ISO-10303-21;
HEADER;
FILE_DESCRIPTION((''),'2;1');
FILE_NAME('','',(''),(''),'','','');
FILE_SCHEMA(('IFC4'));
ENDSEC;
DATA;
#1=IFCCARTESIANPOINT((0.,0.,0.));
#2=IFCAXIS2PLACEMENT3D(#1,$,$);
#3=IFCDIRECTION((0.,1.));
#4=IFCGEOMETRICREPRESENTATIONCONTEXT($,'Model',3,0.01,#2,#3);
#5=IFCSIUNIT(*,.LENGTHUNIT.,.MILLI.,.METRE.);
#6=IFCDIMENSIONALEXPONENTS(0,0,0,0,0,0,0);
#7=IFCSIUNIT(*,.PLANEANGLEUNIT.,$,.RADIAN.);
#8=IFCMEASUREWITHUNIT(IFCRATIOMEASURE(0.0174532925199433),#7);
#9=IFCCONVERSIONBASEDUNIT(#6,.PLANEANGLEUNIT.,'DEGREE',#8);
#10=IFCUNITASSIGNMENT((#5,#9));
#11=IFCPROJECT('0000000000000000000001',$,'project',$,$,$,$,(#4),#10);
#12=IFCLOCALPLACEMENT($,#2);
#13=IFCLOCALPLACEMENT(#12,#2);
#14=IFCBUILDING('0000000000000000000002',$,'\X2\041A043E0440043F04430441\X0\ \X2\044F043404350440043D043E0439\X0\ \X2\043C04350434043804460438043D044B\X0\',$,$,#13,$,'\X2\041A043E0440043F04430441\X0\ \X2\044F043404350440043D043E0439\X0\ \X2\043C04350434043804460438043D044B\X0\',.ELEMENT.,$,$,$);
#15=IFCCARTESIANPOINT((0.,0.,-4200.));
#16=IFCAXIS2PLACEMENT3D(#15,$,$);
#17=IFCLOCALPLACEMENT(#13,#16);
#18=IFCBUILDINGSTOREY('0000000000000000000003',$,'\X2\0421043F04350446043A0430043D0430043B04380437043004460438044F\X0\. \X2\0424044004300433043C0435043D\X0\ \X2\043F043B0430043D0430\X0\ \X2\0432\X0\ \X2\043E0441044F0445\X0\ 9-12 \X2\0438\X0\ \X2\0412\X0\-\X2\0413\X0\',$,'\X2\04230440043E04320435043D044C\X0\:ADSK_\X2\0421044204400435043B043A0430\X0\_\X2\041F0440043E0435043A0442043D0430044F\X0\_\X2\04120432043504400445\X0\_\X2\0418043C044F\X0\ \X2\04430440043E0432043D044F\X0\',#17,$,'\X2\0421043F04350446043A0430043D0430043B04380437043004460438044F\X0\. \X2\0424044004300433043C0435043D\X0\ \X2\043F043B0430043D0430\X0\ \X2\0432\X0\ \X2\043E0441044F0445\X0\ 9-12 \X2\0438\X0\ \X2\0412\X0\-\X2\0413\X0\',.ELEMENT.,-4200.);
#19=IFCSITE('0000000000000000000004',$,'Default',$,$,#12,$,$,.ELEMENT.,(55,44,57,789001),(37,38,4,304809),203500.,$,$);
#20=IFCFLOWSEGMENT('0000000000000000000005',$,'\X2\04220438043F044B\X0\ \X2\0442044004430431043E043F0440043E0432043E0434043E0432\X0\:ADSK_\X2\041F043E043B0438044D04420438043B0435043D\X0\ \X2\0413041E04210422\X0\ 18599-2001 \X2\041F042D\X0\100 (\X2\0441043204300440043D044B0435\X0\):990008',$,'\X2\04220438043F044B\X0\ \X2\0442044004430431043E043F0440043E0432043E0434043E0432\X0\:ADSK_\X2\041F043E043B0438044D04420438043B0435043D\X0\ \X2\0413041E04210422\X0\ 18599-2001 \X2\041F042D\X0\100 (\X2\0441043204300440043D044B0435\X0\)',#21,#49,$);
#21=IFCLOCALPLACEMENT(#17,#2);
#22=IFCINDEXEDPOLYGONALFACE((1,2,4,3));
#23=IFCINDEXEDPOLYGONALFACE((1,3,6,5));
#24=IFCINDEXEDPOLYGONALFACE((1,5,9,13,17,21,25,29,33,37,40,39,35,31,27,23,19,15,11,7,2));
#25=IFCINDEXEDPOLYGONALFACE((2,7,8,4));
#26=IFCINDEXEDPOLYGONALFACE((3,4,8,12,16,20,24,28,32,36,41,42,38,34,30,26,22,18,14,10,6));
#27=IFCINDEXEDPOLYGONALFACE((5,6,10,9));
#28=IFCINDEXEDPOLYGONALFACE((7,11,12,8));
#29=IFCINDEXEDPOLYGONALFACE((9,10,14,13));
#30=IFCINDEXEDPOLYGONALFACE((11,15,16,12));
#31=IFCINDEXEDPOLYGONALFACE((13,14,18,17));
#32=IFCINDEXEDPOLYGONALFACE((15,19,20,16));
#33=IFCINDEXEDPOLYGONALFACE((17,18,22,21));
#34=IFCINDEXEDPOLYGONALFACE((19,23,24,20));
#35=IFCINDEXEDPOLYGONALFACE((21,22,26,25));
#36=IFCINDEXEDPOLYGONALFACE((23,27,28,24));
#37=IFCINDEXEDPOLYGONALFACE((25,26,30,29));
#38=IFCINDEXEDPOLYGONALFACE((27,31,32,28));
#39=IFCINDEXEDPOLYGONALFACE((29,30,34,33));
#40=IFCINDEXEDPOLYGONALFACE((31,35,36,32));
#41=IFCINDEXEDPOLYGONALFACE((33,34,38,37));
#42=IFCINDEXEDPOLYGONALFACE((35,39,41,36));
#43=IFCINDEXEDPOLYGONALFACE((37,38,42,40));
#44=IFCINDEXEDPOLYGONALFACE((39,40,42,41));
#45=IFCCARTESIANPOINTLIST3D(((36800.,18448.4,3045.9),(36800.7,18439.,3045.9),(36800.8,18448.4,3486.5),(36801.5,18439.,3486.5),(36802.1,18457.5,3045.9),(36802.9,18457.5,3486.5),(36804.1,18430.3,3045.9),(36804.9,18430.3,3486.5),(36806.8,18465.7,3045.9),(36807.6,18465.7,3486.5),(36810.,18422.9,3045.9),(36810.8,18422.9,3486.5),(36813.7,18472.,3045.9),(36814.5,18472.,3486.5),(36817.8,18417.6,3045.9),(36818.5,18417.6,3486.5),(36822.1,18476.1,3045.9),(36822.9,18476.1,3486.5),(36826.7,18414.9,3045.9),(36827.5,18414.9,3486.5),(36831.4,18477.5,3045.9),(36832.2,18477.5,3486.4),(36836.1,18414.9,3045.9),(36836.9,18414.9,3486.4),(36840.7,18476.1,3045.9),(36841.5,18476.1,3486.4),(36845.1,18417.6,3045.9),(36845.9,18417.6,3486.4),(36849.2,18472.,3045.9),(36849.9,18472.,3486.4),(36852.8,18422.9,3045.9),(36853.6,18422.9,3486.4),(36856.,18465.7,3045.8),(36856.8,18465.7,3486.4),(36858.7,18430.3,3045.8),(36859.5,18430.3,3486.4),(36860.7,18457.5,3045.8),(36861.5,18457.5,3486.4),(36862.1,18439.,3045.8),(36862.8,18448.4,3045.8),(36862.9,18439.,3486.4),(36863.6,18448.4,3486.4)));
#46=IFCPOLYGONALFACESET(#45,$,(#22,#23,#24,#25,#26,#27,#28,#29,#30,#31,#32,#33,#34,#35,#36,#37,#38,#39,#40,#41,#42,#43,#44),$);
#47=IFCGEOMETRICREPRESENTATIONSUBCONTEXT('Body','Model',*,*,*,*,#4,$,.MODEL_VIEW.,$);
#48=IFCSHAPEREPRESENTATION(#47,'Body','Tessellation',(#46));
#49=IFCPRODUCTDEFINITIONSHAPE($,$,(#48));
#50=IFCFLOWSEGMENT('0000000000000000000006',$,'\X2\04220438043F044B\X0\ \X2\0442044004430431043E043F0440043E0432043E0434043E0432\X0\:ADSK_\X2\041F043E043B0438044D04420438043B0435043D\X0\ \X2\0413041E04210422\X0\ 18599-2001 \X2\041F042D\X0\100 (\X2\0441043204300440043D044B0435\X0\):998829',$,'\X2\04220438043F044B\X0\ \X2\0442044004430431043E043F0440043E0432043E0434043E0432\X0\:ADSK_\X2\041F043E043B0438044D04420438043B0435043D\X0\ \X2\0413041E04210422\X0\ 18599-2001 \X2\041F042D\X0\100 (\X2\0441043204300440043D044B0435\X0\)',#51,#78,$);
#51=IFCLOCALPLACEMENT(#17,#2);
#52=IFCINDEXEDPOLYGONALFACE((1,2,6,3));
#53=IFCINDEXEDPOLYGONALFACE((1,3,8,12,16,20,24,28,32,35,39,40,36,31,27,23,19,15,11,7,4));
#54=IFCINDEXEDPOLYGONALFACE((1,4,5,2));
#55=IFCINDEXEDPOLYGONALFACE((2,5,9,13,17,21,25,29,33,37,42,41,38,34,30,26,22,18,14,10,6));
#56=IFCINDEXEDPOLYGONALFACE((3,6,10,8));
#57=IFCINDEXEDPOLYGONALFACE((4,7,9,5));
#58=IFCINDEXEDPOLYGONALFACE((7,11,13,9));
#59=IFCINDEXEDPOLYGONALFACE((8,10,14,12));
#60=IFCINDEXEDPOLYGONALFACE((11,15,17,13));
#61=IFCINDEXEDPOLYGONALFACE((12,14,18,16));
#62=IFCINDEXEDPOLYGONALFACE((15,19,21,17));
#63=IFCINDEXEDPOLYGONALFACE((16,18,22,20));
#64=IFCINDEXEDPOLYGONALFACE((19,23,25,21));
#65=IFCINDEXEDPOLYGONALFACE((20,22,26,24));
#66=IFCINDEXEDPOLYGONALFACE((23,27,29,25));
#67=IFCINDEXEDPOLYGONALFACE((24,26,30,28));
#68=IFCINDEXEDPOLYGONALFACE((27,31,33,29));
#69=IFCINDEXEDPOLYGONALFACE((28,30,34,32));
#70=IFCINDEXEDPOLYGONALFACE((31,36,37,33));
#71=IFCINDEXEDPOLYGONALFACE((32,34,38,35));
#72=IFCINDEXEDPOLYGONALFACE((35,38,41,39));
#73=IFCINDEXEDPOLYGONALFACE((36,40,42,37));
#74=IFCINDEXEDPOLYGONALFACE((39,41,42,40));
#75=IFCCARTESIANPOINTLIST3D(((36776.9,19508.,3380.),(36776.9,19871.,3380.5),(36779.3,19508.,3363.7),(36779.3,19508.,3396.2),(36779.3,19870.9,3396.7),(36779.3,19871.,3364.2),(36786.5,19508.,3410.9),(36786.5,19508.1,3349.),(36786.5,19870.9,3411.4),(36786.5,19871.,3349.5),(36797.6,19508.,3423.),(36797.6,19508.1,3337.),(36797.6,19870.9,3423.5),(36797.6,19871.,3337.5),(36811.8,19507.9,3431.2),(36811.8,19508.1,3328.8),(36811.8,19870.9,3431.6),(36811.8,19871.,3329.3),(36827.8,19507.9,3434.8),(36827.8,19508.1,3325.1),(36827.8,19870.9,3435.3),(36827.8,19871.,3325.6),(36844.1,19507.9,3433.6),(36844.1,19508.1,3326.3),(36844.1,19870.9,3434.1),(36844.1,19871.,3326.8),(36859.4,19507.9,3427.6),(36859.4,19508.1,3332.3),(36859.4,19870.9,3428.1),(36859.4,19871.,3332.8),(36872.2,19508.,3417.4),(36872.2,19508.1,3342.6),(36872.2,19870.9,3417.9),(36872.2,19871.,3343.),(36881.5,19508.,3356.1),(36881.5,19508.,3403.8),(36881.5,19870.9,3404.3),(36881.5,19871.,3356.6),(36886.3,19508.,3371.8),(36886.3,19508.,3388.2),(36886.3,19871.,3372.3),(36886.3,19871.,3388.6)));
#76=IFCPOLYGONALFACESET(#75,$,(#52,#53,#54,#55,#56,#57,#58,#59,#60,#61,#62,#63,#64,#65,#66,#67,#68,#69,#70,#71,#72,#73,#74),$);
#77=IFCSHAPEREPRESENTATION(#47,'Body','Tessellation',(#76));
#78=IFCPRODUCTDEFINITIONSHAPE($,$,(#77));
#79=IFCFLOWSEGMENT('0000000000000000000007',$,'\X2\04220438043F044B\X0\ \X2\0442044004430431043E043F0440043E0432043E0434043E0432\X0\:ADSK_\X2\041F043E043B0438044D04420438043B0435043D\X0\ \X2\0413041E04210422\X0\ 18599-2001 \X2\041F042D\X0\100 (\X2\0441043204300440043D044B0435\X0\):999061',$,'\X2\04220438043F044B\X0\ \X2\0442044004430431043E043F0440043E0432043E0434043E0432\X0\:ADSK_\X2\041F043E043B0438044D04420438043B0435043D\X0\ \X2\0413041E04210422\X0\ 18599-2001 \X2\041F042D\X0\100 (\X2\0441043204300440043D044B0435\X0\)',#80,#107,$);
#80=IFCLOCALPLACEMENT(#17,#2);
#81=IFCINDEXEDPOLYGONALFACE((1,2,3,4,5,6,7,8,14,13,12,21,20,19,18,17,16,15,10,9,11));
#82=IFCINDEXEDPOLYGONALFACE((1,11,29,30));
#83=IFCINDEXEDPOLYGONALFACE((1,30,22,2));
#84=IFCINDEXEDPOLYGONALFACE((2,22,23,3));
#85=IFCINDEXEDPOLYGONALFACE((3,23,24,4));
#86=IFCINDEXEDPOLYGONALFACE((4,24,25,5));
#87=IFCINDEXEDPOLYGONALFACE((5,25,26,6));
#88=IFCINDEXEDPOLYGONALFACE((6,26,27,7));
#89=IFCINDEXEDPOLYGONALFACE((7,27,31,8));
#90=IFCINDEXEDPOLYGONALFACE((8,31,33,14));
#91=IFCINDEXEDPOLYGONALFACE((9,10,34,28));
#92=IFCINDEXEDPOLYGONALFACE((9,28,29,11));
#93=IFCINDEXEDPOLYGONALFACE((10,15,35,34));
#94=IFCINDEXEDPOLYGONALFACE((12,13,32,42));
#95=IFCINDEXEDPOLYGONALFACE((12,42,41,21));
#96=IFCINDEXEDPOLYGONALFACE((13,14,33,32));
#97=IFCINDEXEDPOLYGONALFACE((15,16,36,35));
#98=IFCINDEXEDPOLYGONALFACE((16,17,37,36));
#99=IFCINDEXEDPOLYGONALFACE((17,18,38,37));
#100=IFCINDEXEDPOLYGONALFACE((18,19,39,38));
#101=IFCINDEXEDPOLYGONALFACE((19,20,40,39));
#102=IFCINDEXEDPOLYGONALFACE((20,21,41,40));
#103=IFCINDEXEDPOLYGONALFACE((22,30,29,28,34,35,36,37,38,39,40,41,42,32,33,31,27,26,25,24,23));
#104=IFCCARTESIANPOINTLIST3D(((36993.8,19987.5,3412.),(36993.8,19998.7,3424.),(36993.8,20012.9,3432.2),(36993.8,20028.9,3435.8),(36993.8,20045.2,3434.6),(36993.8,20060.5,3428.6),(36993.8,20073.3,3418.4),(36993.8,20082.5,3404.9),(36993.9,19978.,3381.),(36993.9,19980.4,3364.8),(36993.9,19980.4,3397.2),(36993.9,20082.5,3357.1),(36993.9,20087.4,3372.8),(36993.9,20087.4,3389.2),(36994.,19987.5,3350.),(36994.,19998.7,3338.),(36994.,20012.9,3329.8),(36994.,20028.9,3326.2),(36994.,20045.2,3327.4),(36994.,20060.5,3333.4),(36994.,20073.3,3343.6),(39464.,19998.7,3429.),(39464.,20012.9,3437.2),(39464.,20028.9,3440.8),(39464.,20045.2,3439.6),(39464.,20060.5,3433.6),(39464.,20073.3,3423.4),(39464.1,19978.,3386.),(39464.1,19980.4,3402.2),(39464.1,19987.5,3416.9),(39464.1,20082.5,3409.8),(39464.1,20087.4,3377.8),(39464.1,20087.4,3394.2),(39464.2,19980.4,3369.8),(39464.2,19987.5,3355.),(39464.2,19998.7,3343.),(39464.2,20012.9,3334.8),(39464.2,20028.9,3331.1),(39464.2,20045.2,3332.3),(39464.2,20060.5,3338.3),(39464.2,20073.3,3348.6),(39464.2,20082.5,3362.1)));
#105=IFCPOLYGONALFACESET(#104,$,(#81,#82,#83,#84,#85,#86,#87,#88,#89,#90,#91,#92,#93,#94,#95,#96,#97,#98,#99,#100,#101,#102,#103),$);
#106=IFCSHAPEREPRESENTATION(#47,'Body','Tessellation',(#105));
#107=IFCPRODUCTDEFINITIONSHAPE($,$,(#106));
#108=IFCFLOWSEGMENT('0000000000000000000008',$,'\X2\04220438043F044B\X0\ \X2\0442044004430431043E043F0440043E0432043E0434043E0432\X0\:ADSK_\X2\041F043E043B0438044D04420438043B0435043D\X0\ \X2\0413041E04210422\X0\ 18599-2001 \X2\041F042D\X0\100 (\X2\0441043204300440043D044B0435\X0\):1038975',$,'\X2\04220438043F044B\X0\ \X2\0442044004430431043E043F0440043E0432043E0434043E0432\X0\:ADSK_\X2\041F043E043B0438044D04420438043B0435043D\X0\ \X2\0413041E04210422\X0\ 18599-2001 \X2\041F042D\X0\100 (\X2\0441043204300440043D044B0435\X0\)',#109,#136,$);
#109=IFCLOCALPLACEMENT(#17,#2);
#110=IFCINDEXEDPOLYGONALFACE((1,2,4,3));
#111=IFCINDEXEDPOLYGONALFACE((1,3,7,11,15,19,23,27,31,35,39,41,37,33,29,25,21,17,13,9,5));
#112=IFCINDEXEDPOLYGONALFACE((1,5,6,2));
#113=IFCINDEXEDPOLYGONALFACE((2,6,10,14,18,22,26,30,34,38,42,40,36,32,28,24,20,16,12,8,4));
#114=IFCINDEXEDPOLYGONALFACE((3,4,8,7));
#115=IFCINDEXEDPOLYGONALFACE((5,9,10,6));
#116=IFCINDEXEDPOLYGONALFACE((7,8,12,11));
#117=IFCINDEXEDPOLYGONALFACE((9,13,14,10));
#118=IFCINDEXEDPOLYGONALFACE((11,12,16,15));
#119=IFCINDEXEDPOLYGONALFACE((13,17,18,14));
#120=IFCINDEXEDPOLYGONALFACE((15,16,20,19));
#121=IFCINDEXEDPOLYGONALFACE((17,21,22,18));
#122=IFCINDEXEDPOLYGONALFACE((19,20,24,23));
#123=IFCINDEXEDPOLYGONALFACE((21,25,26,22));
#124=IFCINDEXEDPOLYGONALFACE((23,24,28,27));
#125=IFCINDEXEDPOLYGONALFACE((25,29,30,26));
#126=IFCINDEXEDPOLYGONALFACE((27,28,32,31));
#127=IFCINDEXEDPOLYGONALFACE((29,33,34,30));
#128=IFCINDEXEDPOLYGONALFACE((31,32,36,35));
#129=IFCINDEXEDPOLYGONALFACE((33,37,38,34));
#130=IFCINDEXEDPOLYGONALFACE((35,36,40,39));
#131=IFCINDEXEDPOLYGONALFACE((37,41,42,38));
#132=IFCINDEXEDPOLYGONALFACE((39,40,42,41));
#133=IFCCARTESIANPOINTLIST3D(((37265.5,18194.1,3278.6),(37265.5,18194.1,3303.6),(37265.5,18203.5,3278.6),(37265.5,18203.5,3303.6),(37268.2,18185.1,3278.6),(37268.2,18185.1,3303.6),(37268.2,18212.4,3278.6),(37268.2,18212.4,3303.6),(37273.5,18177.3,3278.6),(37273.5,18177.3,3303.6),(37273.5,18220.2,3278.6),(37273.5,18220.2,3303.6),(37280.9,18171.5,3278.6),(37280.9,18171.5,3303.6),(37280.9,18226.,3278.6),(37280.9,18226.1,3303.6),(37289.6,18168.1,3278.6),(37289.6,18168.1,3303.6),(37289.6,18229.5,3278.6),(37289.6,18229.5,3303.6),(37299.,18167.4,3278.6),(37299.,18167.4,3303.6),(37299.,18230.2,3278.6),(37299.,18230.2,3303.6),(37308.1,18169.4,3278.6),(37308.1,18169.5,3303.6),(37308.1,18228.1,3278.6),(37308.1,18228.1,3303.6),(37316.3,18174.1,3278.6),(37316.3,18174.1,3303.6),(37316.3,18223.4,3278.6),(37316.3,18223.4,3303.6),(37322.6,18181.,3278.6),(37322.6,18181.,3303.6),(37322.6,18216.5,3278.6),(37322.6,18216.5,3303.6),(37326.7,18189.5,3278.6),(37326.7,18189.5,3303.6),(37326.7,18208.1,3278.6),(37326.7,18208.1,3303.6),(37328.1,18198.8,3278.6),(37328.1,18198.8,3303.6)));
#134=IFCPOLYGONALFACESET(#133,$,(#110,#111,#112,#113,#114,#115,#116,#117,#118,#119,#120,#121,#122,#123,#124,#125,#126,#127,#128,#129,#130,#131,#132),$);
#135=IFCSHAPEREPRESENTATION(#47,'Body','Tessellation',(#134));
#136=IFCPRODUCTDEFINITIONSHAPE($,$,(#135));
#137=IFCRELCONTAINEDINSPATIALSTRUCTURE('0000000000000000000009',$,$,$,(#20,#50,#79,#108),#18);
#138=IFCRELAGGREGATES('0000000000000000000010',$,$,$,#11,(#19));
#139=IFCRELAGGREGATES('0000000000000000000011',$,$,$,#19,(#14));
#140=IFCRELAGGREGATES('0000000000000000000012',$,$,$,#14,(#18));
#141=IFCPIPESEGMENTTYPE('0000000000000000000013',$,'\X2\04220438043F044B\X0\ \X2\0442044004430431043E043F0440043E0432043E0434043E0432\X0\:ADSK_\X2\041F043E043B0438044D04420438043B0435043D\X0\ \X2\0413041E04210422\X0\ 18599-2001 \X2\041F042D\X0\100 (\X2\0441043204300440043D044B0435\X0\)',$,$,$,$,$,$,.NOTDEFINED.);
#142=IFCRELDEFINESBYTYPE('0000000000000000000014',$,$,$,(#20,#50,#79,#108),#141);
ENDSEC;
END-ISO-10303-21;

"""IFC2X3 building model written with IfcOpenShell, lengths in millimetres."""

from ifc_helpers import new_model, entity, si_unit, converted_unit, direction, frame, origin, origin_2d_with_axis, place, context, subcontext, project, spatial, circle, extrude, type_object, element, save


model = new_model("IFC2X3")

# Units and contexts
model_context = context("Model", 3, precision=0.01, world=origin(), true_north=direction((0.0, 1.0)))
body_context = subcontext(model_context, "Body", "Model", "MODEL_VIEW")
ifc_project = project(units=[si_unit("LENGTHUNIT", "METRE", prefix="MILLI"), converted_unit("PLANEANGLEUNIT", "DEGREE", entity("IfcRatioMeasure", 0.0174532925199433), si_unit("PLANEANGLEUNIT", "RADIAN"), dimensions=[0, 0, 0, 0, 0, 0, 0])], contexts=[model_context])

# Site, building, storey
site_placement = place(None, origin())
site = spatial("IfcSite", under=ifc_project, at=site_placement, Name="Default", CompositionType="ELEMENT", RefLatitude=(55, 44, 57, 789001), RefLongitude=(37, 38, 4, 304809), RefElevation=203500.0)
building_placement = place(site_placement, origin())
building = spatial("IfcBuilding", under=site, at=building_placement, Name="Корпус ядерной медицины", LongName="Корпус ядерной медицины", CompositionType="ELEMENT")
storey_placement = place(building_placement, frame((0.0, 0.0, -4200.0)))
storey = spatial("IfcBuildingStorey", under=building, at=storey_placement, Name="Спецканализация. Фрагмен плана в осях 9-12 и В-Г", ObjectType="Уровень:ADSK_Стрелка_Проектная_Вверх_Имя уровня", LongName="Спецканализация. Фрагмен плана в осях 9-12 и В-Г", CompositionType="ELEMENT", Elevation=-4200.0)

# Flow segments
pipe_segment_type = type_object("IfcPipeSegmentType", Name="Типы трубопроводов:ADSK_Полиэтилен ГОСТ 18599-2001 ПЭ100 (сварные)", PredefinedType="NOTDEFINED")
flow_segment_1_placement = place(storey_placement, frame((36798.3, 18412.9, 3045.8)))
element("IfcFlowSegment", 1, at=flow_segment_1_placement, inside=storey, type_object=pipe_segment_type, Name="Типы трубопроводов:ADSK_Полиэтилен ГОСТ 18599-2001 ПЭ100 (сварные):990008", ObjectType="Типы трубопроводов:ADSK_Полиэтилен ГОСТ 18599-2001 ПЭ100 (сварные)", context=body_context, shape_type="SweptSolid", body=[
    extrude(circle(Radius=31.5, at=origin_2d_with_axis()), frame((33.1, 33.1, 0.1), z_axis=(0.001773, 0.0, 0.999998), x_axis=(0.0, 1.0, 0.0)), (0.0, 0.0, 1.0), 440.6),
])
flow_segment_2_placement = place(storey_placement, frame((36775.3, 19507.9, 3323.4)))
element("IfcFlowSegment", 2, at=flow_segment_2_placement, inside=storey, type_object=pipe_segment_type, Name="Типы трубопроводов:ADSK_Полиэтилен ГОСТ 18599-2001 ПЭ100 (сварные):998829", ObjectType="Типы трубопроводов:ADSK_Полиэтилен ГОСТ 18599-2001 ПЭ100 (сварные)", context=body_context, shape_type="SweptSolid", body=[
    extrude(circle(Radius=55.0, at=origin_2d_with_axis()), frame((56.6, 0.1, 56.6), z_axis=(0.0, 0.999999, 0.001352), x_axis=(-1.0, 0.0, 0.0)), (0.0, 0.0, 1.0), 363.0),
])
flow_segment_3_placement = place(storey_placement, frame((36993.8, 19976.4, 3324.4)))
element("IfcFlowSegment", 3, at=flow_segment_3_placement, inside=storey, type_object=pipe_segment_type, Name="Типы трубопроводов:ADSK_Полиэтилен ГОСТ 18599-2001 ПЭ100 (сварные):999061", ObjectType="Типы трубопроводов:ADSK_Полиэтилен ГОСТ 18599-2001 ПЭ100 (сварные)", context=body_context, shape_type="SweptSolid", body=[
    extrude(circle(Radius=55.0, at=origin_2d_with_axis()), frame((0.1, 56.6, 56.6), z_axis=(0.999998, 0.0, 0.00201), x_axis=(0.0, -1.0, 0.0)), (0.0, 0.0, 1.0), 2470.2),
])
flow_segment_4_placement = place(storey_placement, frame((37263.5, 18165.7, 3278.6)))
element("IfcFlowSegment", 4, at=flow_segment_4_placement, inside=storey, type_object=pipe_segment_type, Name="Типы трубопроводов:ADSK_Полиэтилен ГОСТ 18599-2001 ПЭ100 (сварные):1038975", ObjectType="Типы трубопроводов:ADSK_Полиэтилен ГОСТ 18599-2001 ПЭ100 (сварные)", context=body_context, shape_type="SweptSolid", body=[
    extrude(circle(Radius=31.5, at=origin_2d_with_axis()), frame((33.1, 33.1, 0.0), z_axis=(-0.000078, 0.000119, 1.0), x_axis=(1.0, 0.0, 0.000078)), (0.0, 0.0, 1.0), 25.0),
])

save(model, "model.ifc")
